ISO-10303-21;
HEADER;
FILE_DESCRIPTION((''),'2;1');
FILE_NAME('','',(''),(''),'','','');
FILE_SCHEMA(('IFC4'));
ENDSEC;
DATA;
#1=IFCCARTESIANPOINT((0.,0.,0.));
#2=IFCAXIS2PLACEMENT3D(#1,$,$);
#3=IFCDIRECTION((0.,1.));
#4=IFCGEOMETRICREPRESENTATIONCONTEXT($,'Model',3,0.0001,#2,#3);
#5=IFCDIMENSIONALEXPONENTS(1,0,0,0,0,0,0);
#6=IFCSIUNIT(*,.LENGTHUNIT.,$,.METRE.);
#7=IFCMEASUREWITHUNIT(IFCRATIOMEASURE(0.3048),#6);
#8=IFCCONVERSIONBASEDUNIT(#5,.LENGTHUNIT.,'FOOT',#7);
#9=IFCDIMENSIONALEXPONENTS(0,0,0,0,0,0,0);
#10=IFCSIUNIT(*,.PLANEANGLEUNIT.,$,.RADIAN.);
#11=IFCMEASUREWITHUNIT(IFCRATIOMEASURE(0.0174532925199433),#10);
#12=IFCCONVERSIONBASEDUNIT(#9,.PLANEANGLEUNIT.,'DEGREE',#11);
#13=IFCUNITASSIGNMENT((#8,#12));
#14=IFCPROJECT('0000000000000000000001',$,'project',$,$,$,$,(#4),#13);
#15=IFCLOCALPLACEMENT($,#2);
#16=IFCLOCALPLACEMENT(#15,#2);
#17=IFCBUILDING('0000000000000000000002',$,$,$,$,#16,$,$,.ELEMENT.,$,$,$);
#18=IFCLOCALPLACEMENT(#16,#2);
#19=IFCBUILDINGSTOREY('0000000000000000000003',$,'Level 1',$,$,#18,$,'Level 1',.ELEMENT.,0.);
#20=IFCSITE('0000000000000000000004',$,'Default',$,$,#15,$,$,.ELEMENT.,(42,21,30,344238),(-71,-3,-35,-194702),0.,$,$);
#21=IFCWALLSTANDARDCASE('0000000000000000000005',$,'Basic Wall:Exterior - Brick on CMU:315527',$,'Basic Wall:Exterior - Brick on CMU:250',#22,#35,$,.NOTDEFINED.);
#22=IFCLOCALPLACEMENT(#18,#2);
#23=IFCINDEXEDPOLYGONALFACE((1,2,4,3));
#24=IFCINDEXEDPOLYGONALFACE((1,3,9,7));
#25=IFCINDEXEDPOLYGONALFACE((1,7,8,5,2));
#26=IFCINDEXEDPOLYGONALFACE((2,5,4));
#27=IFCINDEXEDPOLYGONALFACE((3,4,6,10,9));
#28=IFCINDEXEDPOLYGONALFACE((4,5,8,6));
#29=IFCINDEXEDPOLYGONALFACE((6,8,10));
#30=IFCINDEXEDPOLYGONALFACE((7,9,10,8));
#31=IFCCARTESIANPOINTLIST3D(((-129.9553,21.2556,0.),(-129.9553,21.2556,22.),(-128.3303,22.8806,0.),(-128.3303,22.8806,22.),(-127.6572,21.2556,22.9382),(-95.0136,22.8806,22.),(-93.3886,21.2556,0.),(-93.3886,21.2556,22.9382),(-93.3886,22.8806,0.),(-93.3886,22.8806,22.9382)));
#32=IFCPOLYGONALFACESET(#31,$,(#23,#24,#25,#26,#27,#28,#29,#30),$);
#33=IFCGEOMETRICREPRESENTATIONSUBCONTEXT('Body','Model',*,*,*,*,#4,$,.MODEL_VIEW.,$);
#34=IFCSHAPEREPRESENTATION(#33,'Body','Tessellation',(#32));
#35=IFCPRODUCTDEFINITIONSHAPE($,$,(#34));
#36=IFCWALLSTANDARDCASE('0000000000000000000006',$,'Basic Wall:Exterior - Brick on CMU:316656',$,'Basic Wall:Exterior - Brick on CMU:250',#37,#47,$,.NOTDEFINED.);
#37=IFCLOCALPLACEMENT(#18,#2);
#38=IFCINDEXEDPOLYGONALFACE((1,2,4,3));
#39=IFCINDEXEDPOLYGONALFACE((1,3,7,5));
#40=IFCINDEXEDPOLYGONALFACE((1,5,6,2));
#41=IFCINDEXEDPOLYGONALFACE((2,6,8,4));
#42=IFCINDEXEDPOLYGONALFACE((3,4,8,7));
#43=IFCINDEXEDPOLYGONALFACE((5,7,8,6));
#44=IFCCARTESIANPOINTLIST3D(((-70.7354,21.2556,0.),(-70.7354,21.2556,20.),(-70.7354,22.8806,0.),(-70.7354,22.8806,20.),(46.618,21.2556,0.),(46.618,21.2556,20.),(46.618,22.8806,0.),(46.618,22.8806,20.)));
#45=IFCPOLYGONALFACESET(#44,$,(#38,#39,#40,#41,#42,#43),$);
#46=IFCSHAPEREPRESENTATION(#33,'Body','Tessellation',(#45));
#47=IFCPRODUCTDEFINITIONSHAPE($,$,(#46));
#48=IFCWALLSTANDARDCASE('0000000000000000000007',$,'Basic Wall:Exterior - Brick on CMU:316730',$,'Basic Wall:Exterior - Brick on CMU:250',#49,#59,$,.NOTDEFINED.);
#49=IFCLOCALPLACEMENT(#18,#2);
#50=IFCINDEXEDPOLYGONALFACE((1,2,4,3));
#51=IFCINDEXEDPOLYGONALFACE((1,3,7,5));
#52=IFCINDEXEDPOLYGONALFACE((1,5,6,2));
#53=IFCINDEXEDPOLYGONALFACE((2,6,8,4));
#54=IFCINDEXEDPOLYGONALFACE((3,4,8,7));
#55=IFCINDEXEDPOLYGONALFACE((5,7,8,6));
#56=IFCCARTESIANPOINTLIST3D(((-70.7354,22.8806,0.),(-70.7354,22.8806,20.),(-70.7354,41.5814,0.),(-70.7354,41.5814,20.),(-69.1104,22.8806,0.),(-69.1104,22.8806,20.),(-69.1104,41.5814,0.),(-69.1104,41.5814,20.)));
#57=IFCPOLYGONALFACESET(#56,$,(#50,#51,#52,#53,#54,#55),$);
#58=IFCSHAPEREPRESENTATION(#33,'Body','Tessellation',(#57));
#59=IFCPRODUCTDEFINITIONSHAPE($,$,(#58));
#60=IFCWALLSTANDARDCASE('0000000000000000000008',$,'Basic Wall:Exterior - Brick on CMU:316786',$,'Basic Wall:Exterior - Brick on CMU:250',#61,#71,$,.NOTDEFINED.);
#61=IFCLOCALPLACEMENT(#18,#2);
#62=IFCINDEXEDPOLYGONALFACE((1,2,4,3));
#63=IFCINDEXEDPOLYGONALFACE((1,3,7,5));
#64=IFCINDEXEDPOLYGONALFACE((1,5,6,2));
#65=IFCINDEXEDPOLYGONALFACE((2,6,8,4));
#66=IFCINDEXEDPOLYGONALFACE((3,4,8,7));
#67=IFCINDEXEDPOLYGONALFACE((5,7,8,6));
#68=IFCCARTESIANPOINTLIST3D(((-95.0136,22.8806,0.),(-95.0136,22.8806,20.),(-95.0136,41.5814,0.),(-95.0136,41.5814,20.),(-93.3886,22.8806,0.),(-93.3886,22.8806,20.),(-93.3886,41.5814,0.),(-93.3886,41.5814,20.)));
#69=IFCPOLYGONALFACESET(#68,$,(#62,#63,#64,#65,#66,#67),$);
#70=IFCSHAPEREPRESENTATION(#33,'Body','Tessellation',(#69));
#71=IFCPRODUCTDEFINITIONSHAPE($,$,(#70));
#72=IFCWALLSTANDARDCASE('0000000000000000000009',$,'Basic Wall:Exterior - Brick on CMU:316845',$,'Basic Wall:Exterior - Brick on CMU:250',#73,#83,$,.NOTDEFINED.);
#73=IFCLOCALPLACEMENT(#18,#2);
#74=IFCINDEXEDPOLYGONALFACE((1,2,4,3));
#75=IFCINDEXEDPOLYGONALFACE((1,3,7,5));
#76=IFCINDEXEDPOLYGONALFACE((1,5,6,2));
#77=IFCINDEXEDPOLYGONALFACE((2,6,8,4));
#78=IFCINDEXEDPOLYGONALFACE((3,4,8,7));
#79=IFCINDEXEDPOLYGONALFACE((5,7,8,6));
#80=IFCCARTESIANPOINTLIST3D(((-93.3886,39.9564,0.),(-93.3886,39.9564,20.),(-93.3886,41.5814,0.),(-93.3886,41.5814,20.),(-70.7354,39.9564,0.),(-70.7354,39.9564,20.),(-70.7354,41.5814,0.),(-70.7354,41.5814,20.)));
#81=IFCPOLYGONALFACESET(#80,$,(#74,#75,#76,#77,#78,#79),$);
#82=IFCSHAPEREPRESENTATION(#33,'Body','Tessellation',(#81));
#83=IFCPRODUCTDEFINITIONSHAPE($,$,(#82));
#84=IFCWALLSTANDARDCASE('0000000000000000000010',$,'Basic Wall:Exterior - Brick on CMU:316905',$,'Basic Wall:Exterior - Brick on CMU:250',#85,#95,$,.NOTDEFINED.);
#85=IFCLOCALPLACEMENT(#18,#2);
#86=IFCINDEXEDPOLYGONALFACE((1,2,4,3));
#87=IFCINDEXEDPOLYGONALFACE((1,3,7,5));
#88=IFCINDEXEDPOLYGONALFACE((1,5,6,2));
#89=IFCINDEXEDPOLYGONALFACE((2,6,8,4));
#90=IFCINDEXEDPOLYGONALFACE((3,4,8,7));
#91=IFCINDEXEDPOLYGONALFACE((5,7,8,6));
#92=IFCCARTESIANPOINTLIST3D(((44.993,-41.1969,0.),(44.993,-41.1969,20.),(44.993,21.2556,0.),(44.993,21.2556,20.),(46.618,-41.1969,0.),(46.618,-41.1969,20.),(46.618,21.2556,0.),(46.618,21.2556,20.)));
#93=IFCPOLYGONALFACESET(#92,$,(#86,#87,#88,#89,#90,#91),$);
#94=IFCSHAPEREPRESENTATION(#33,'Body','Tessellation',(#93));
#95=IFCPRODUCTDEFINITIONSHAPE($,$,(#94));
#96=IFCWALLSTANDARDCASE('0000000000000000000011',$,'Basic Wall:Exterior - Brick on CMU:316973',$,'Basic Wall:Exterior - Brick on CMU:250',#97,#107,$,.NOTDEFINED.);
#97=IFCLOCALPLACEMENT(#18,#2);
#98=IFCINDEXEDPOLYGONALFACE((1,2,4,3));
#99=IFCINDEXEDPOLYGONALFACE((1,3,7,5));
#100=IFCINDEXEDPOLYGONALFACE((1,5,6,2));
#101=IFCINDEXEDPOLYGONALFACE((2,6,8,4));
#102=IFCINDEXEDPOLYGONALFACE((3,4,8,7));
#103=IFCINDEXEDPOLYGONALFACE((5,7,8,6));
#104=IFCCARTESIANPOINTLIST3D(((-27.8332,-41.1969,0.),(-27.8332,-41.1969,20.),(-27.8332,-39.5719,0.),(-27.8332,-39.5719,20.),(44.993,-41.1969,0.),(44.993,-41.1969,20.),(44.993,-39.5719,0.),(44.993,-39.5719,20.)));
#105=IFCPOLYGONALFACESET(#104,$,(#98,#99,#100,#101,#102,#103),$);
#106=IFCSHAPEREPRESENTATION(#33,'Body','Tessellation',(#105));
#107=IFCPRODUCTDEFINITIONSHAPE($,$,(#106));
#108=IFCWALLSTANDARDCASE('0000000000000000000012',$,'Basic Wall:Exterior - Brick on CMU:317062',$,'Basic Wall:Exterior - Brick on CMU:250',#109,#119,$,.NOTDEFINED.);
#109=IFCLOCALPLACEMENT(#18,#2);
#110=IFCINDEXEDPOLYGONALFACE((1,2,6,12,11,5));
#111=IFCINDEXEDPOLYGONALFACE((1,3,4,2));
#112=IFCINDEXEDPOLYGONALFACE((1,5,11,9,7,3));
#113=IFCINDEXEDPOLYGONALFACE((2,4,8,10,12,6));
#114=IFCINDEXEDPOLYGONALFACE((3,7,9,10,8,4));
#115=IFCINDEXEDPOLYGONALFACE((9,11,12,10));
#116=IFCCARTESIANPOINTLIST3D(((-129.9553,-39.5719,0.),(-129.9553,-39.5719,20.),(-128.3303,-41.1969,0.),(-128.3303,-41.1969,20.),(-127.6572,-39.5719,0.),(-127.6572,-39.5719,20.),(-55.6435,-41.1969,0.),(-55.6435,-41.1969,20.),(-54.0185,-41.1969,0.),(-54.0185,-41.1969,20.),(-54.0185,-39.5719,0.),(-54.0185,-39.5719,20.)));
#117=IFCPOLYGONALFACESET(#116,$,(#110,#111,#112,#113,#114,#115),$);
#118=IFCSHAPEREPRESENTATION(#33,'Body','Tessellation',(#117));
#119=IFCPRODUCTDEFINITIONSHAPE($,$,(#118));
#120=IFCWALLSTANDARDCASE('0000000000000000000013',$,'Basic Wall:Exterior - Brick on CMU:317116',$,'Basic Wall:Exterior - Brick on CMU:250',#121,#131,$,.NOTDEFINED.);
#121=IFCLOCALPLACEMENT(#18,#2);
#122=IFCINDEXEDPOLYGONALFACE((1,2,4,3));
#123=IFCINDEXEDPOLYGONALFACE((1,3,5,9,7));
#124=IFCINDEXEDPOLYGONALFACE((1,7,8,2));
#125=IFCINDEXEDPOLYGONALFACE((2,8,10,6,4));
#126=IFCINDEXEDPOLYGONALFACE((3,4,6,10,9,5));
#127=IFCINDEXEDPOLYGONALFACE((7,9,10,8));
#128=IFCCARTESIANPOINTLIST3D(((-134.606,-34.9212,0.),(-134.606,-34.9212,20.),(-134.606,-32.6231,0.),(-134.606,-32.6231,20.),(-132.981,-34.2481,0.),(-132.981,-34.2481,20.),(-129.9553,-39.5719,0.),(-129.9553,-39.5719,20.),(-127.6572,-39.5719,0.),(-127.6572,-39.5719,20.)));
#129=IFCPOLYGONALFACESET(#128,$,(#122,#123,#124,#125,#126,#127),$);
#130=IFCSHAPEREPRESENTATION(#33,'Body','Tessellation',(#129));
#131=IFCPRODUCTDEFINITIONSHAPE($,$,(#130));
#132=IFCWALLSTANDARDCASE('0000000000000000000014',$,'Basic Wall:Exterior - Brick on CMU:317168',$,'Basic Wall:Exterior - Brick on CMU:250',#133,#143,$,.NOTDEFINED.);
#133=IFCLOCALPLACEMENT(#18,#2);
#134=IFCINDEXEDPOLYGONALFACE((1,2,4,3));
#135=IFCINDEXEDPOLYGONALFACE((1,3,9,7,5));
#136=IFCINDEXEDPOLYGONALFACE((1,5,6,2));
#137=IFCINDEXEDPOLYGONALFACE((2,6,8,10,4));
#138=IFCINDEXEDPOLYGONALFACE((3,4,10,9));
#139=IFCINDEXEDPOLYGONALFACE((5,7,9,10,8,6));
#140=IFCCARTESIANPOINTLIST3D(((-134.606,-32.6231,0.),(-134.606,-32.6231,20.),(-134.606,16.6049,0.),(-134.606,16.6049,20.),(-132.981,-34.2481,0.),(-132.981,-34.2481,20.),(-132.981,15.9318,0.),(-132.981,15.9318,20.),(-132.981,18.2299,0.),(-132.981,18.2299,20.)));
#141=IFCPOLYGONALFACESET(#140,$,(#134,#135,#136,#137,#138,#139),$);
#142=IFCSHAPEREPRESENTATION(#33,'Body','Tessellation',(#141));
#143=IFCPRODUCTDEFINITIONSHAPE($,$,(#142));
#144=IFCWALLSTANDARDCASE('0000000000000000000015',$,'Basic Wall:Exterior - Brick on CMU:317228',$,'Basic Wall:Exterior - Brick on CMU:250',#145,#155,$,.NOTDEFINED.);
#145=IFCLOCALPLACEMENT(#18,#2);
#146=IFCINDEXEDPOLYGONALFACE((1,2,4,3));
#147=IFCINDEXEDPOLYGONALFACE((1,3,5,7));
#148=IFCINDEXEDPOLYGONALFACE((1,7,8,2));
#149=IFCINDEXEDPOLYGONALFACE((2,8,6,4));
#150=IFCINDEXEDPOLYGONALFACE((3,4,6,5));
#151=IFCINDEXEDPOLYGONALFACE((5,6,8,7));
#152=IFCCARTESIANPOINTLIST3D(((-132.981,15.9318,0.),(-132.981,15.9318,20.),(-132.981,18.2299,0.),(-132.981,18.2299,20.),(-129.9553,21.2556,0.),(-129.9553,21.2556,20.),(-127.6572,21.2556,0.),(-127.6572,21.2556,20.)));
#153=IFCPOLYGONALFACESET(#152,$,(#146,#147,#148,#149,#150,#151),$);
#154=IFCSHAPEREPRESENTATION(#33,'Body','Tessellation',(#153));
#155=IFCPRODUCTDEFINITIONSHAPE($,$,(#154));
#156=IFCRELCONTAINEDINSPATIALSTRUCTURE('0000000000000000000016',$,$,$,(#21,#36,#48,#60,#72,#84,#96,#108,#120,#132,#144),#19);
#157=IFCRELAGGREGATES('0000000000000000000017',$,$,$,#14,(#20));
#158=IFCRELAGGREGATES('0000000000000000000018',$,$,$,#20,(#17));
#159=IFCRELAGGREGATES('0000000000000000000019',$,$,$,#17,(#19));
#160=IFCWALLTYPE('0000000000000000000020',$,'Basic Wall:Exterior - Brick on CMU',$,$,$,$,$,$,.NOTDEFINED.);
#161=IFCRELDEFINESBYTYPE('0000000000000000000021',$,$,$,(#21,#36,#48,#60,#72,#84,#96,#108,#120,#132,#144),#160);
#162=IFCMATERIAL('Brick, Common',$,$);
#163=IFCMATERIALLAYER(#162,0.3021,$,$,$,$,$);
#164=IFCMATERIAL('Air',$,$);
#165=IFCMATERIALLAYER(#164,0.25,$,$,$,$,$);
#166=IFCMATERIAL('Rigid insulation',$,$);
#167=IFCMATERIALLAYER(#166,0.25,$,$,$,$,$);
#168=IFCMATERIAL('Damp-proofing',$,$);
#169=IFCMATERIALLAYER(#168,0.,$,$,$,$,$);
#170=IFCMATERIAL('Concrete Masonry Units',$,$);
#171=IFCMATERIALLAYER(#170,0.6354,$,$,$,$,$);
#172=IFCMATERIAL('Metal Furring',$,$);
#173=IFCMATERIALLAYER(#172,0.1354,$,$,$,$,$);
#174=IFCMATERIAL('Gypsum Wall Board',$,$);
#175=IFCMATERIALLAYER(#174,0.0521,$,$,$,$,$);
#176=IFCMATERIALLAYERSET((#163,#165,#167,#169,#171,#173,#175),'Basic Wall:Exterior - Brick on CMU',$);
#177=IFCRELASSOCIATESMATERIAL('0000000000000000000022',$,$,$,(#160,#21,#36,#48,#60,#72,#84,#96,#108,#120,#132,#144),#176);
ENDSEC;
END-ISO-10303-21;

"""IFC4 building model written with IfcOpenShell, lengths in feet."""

from ifc_helpers import new_model, entity, si_unit, converted_unit, direction, frame, frame_2d, origin, place, context, subcontext, project, spatial, polyline, rectangle, outline, extrude, clip, bounded_halfspace, material, layer, layer_set, layer_usage, type_object, element, save


model = new_model("IFC4")

# Units and contexts
model_context = context("Model", 3, precision=0.0001, world=origin(), true_north=direction((0.0, 1.0)))
body_context = subcontext(model_context, "Body", "Model", "MODEL_VIEW")
ifc_project = project(units=[converted_unit("LENGTHUNIT", "FOOT", entity("IfcRatioMeasure", 0.3048), si_unit("LENGTHUNIT", "METRE"), dimensions=[1, 0, 0, 0, 0, 0, 0]), converted_unit("PLANEANGLEUNIT", "DEGREE", entity("IfcRatioMeasure", 0.0174532925199433), si_unit("PLANEANGLEUNIT", "RADIAN"), dimensions=[0, 0, 0, 0, 0, 0, 0])], contexts=[model_context])

# Site, building, storey
site_placement = place(None, origin())
site = spatial("IfcSite", under=ifc_project, at=site_placement, Name="Default", CompositionType="ELEMENT", RefLatitude=(42, 21, 30, 344238), RefLongitude=(-71, -3, -35, -194702), RefElevation=0.0)
building_placement = place(site_placement, origin())
building = spatial("IfcBuilding", under=site, at=building_placement, CompositionType="ELEMENT")
storey_placement = place(building_placement, origin())
storey = spatial("IfcBuildingStorey", under=building, at=storey_placement, Name="Level 1", LongName="Level 1", CompositionType="ELEMENT", Elevation=0.0)

# Walls
ifc_material_1 = material(Name="Brick, Common")
ifc_layer_1 = layer(ifc_material_1, 0.3021)
ifc_material_2 = material(Name="Air")
ifc_layer_2 = layer(ifc_material_2, 0.25)
ifc_material_3 = material(Name="Rigid insulation")
ifc_layer_3 = layer(ifc_material_3, 0.25)
ifc_material_4 = material(Name="Damp-proofing")
ifc_layer_4 = layer(ifc_material_4, 0.0)
ifc_material_5 = material(Name="Concrete Masonry Units")
ifc_layer_5 = layer(ifc_material_5, 0.6354)
ifc_material_6 = material(Name="Metal Furring")
ifc_layer_6 = layer(ifc_material_6, 0.1354)
ifc_material_7 = material(Name="Gypsum Wall Board")
ifc_layer_7 = layer(ifc_material_7, 0.0521)
ifc_layer_set = layer_set([ifc_layer_1, ifc_layer_2, ifc_layer_3, ifc_layer_4, ifc_layer_5, ifc_layer_6, ifc_layer_7], Name="Basic Wall:Exterior - Brick on CMU")
ifc_layer_usage_1 = layer_usage(ifc_layer_set, "AXIS2", "NEGATIVE", 0.8125)
wall_type = type_object("IfcWallType", Name="Basic Wall:Exterior - Brick on CMU", PredefinedType="NOTDEFINED", material=ifc_layer_set)
wall_1_placement = place(storey_placement, frame((-129.9553, 22.0681, 0.0)))
element("IfcWallStandardCase", 1, at=wall_1_placement, inside=storey, type_object=wall_type, material=ifc_layer_usage_1, Name="Basic Wall:Exterior - Brick on CMU:315527", ObjectType="Basic Wall:Exterior - Brick on CMU:250", PredefinedType="NOTDEFINED", context=body_context, shape_type="Clipping", body=[
    clip(clip(clip(extrude(outline(polyline([(36.5667, -0.8125), (36.5667, 0.8125), (34.9417, 0.8125), (1.625, 0.8125), (0.0, -0.8125), (2.2981, -0.8125), (36.5667, -0.8125)])), origin(), (0.0, 0.0, 1.0), 22.9382), bounded_halfspace(frame((2.2981, -0.8125, 22.9382), z_axis=(0.0, 0.5, 0.866025), x_axis=(-1.0, 0.0, 0.0)), False, frame((2.2981, -0.8125, 22.9382)), polyline([(0.0, 0.0), (34.2686, 0.0), (32.6436, 1.625), (-0.6731, 1.625), (0.0, 0.0)]))), bounded_halfspace(frame((0.0, -0.8125, 22.0), z_axis=(-0.353553, 0.353553, 0.866025), x_axis=(-0.707107, -0.707107, 0.0)), False, frame((0.0, -0.8125, 22.0)), polyline([(0.0, 0.0), (2.2981, 0.0), (1.625, 1.625), (0.0, 0.0)]))), bounded_halfspace(frame((36.5667, -0.8125, 22.9382), z_axis=(-0.5, 0.0, 0.866025), x_axis=(0.0, -1.0, 0.0)), False, frame((36.5667, -0.8125, 22.9382)), polyline([(0.0, 0.0), (0.0, 1.625), (-1.625, 1.625), (0.0, 0.0)]))),
])
ifc_layer_usage_2 = layer_usage(ifc_layer_set, "AXIS2", "NEGATIVE", 0.8125)
wall_2_placement = place(storey_placement, frame((46.618, 22.0681, 0.0), z_axis=(0.0, 0.0, 1.0), x_axis=(-1.0, 0.0, 0.0)))
element("IfcWallStandardCase", 2, at=wall_2_placement, inside=storey, type_object=wall_type, material=ifc_layer_usage_2, Name="Basic Wall:Exterior - Brick on CMU:316656", ObjectType="Basic Wall:Exterior - Brick on CMU:250", PredefinedType="NOTDEFINED", context=body_context, shape_type="SweptSolid", body=[
    extrude(rectangle(XDim=117.3534, YDim=1.625, at=frame_2d((58.6767, 0.0), x_axis=(-1.0, 0.0))), origin(), (0.0, 0.0, 1.0), 20.0),
])
ifc_layer_usage_3 = layer_usage(ifc_layer_set, "AXIS2", "NEGATIVE", 0.8125)
wall_3_placement = place(storey_placement, frame((-69.9229, 41.5814, 0.0), z_axis=(0.0, 0.0, 1.0), x_axis=(0.0, -1.0, 0.0)))
element("IfcWallStandardCase", 3, at=wall_3_placement, inside=storey, type_object=wall_type, material=ifc_layer_usage_3, Name="Basic Wall:Exterior - Brick on CMU:316730", ObjectType="Basic Wall:Exterior - Brick on CMU:250", PredefinedType="NOTDEFINED", context=body_context, shape_type="SweptSolid", body=[
    extrude(rectangle(XDim=18.7008, YDim=1.625, at=frame_2d((9.3504, 0.0), x_axis=(-1.0, 0.0))), origin(), (0.0, 0.0, 1.0), 20.0),
])
ifc_layer_usage_4 = layer_usage(ifc_layer_set, "AXIS2", "NEGATIVE", 0.8125)
wall_4_placement = place(storey_placement, frame((-94.2011, 22.8806, 0.0), z_axis=(0.0, 0.0, 1.0), x_axis=(0.0, 1.0, 0.0)))
element("IfcWallStandardCase", 4, at=wall_4_placement, inside=storey, type_object=wall_type, material=ifc_layer_usage_4, Name="Basic Wall:Exterior - Brick on CMU:316786", ObjectType="Basic Wall:Exterior - Brick on CMU:250", PredefinedType="NOTDEFINED", context=body_context, shape_type="SweptSolid", body=[
    extrude(rectangle(XDim=18.7008, YDim=1.625, at=frame_2d((9.3504, 0.0), x_axis=(-1.0, 0.0))), origin(), (0.0, 0.0, 1.0), 20.0),
])
ifc_layer_usage_5 = layer_usage(ifc_layer_set, "AXIS2", "NEGATIVE", 0.8125)
wall_5_placement = place(storey_placement, frame((-70.7354, 40.7689, 0.0), z_axis=(0.0, 0.0, 1.0), x_axis=(-1.0, 0.0, 0.0)))
element("IfcWallStandardCase", 5, at=wall_5_placement, inside=storey, type_object=wall_type, material=ifc_layer_usage_5, Name="Basic Wall:Exterior - Brick on CMU:316845", ObjectType="Basic Wall:Exterior - Brick on CMU:250", PredefinedType="NOTDEFINED", context=body_context, shape_type="SweptSolid", body=[
    extrude(rectangle(XDim=22.6532, YDim=1.625, at=frame_2d((11.3266, 0.0), x_axis=(-1.0, 0.0))), origin(), (0.0, 0.0, 1.0), 20.0),
])
ifc_layer_usage_6 = layer_usage(ifc_layer_set, "AXIS2", "NEGATIVE", 0.8125)
wall_6_placement = place(storey_placement, frame((45.8055, 21.2556, 0.0), z_axis=(0.0, 0.0, 1.0), x_axis=(0.0, -1.0, 0.0)))
element("IfcWallStandardCase", 6, at=wall_6_placement, inside=storey, type_object=wall_type, material=ifc_layer_usage_6, Name="Basic Wall:Exterior - Brick on CMU:316905", ObjectType="Basic Wall:Exterior - Brick on CMU:250", PredefinedType="NOTDEFINED", context=body_context, shape_type="SweptSolid", body=[
    extrude(rectangle(XDim=62.4525, YDim=1.625, at=frame_2d((31.2263, 0.0), x_axis=(-1.0, 0.0))), origin(), (0.0, 0.0, 1.0), 20.0),
])
ifc_layer_usage_7 = layer_usage(ifc_layer_set, "AXIS2", "NEGATIVE", 0.8125)
wall_7_placement = place(storey_placement, frame((44.993, -40.3844, 0.0), z_axis=(0.0, 0.0, 1.0), x_axis=(-1.0, 0.0, 0.0)))
element("IfcWallStandardCase", 7, at=wall_7_placement, inside=storey, type_object=wall_type, material=ifc_layer_usage_7, Name="Basic Wall:Exterior - Brick on CMU:316973", ObjectType="Basic Wall:Exterior - Brick on CMU:250", PredefinedType="NOTDEFINED", context=body_context, shape_type="SweptSolid", body=[
    extrude(rectangle(XDim=72.8262, YDim=1.625, at=frame_2d((36.4131, 0.0), x_axis=(-1.0, 0.0))), origin(), (0.0, 0.0, 1.0), 20.0),
])
ifc_layer_usage_8 = layer_usage(ifc_layer_set, "AXIS2", "NEGATIVE", 0.8125)
wall_8_placement = place(storey_placement, frame((-54.0185, -40.3844, 0.0), z_axis=(0.0, 0.0, 1.0), x_axis=(-1.0, 0.0, 0.0)))
element("IfcWallStandardCase", 8, at=wall_8_placement, inside=storey, type_object=wall_type, material=ifc_layer_usage_8, Name="Basic Wall:Exterior - Brick on CMU:317062", ObjectType="Basic Wall:Exterior - Brick on CMU:250", PredefinedType="NOTDEFINED", context=body_context, shape_type="SweptSolid", body=[
    extrude(outline(polyline([(75.9368, -0.8125), (74.3118, 0.8125), (1.625, 0.8125), (0.0, 0.8125), (0.0, -0.8125), (73.6387, -0.8125), (75.9368, -0.8125)])), origin(), (0.0, 0.0, 1.0), 20.0),
])
ifc_layer_usage_9 = layer_usage(ifc_layer_set, "AXIS2", "NEGATIVE", 0.8125)
wall_9_placement = place(storey_placement, frame((-128.2317, -40.1464, 0.0), z_axis=(0.0, 0.0, 1.0), x_axis=(-0.707107, 0.707107, 0.0)))
element("IfcWallStandardCase", 9, at=wall_9_placement, inside=storey, type_object=wall_type, material=ifc_layer_usage_9, Name="Basic Wall:Exterior - Brick on CMU:317116", ObjectType="Basic Wall:Exterior - Brick on CMU:250", PredefinedType="NOTDEFINED", context=body_context, shape_type="SweptSolid", body=[
    extrude(outline(polyline([(9.8271, -0.8125), (8.2021, 0.8125), (1.625, 0.8125), (0.0, -0.8125), (7.529, -0.8125), (9.8271, -0.8125)])), origin(), (0.0, 0.0, 1.0), 20.0),
])
ifc_layer_usage_10 = layer_usage(ifc_layer_set, "AXIS2", "NEGATIVE", 0.8125)
wall_10_placement = place(storey_placement, frame((-133.7935, -34.2481, 0.0), z_axis=(0.0, 0.0, 1.0), x_axis=(0.0, 1.0, 0.0)))
element("IfcWallStandardCase", 10, at=wall_10_placement, inside=storey, type_object=wall_type, material=ifc_layer_usage_10, Name="Basic Wall:Exterior - Brick on CMU:317168", ObjectType="Basic Wall:Exterior - Brick on CMU:250", PredefinedType="NOTDEFINED", context=body_context, shape_type="SweptSolid", body=[
    extrude(outline(polyline([(52.478, -0.8125), (50.853, 0.8125), (1.625, 0.8125), (0.0, -0.8125), (50.1799, -0.8125), (52.478, -0.8125)])), origin(), (0.0, 0.0, 1.0), 20.0),
])
ifc_layer_usage_11 = layer_usage(ifc_layer_set, "AXIS2", "NEGATIVE", 0.8125)
wall_11_placement = place(storey_placement, frame((-133.5555, 16.5063, 0.0), z_axis=(0.0, 0.0, 1.0), x_axis=(0.707107, 0.707107, 0.0)))
element("IfcWallStandardCase", 11, at=wall_11_placement, inside=storey, type_object=wall_type, material=ifc_layer_usage_11, Name="Basic Wall:Exterior - Brick on CMU:317228", ObjectType="Basic Wall:Exterior - Brick on CMU:250", PredefinedType="NOTDEFINED", context=body_context, shape_type="SweptSolid", body=[
    extrude(outline(polyline([(7.529, -0.8125), (5.904, 0.8125), (1.625, 0.8125), (0.0, -0.8125), (7.529, -0.8125)])), origin(), (0.0, 0.0, 1.0), 20.0),
])

save(model, "model.ifc")
